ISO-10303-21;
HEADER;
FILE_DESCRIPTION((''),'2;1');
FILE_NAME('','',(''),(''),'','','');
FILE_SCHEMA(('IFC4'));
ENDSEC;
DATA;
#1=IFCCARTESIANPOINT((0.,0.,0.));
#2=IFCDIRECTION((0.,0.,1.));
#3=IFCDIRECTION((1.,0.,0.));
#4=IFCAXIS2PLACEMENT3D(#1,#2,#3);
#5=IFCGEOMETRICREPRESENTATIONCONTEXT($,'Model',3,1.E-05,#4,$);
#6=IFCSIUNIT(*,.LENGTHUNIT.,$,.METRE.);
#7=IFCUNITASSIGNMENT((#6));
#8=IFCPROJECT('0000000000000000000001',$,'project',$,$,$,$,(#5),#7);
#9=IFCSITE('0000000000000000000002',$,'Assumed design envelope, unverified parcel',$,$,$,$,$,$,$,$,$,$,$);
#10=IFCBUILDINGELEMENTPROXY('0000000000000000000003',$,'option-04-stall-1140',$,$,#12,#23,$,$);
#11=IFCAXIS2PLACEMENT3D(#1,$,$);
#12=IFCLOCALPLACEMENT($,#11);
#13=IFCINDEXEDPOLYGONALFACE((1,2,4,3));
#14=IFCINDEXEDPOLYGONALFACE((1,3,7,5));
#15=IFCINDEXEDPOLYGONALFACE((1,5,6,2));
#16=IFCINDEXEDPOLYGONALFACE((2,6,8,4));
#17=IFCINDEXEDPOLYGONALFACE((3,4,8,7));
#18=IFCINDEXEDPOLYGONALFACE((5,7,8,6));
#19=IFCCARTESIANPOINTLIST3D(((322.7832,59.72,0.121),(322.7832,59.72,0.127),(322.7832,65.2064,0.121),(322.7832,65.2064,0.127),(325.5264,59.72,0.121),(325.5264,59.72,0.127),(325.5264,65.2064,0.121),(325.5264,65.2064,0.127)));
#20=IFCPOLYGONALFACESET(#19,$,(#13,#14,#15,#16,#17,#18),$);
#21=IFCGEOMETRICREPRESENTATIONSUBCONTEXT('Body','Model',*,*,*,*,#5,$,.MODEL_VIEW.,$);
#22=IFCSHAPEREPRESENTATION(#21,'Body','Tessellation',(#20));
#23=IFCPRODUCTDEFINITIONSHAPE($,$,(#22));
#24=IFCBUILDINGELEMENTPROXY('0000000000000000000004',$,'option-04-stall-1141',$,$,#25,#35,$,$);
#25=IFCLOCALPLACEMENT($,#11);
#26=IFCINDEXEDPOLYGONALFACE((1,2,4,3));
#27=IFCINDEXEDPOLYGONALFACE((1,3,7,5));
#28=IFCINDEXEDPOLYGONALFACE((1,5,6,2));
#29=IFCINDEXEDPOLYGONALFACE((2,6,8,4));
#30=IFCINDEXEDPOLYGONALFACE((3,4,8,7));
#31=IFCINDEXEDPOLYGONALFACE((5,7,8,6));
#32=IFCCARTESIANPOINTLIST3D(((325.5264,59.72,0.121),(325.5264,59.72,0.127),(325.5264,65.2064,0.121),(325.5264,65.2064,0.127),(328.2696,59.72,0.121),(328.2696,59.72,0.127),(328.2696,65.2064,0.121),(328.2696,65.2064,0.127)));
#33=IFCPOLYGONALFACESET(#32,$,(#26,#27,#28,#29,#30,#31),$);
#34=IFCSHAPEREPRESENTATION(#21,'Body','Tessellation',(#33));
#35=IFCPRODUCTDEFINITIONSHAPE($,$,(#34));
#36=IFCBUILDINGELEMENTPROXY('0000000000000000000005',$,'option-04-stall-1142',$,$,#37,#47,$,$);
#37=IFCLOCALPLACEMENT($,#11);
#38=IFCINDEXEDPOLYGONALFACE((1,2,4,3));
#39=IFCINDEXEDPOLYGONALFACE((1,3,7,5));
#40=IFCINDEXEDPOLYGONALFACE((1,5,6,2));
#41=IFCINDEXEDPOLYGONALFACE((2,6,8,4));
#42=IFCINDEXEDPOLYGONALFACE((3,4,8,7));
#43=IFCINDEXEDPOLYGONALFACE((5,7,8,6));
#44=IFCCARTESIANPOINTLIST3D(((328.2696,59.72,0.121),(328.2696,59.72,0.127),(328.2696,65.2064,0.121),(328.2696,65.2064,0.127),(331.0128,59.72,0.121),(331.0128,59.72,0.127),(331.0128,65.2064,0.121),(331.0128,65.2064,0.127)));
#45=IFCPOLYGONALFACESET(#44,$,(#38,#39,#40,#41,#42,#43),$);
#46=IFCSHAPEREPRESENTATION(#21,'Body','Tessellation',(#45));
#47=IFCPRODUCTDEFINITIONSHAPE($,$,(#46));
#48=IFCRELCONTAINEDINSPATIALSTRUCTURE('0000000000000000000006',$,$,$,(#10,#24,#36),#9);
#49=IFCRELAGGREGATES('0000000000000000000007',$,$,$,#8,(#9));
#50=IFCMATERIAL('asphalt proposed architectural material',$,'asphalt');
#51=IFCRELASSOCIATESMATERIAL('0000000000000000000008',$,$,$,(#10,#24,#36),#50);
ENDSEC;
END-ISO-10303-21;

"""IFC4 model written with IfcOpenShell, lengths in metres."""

from ifc_helpers import new_model, si_unit, frame, origin_with_axes, place, context, subcontext, project, spatial, rectangle, extrude, material, element, save


model = new_model("IFC4")

# Units and contexts
model_context = context("Model", 3, precision=1e-05, world=origin_with_axes())
body_context = subcontext(model_context, "Body", "Model", "MODEL_VIEW")
ifc_project = project(units=[si_unit("LENGTHUNIT", "METRE")], contexts=[model_context])

# Site
site = spatial("IfcSite", under=ifc_project, Name="Assumed design envelope, unverified parcel")

# Building element proxies
ifc_material = material(Name="asphalt proposed architectural material", Category="asphalt")
for number, where, z_axis, x_axis, name in (
    (1, (324.1548, 62.4632, 0.121), (0.0, 0.0, 1.0), (1.0, 0.0, 0.0), "option-04-stall-1140"),
    (2, (326.898, 62.4632, 0.121), (0.0, 0.0, 1.0), (1.0, 0.0, 0.0), "option-04-stall-1141"),
    (3, (329.6412, 62.4632, 0.121), (0.0, 0.0, 1.0), (1.0, 0.0, 0.0), "option-04-stall-1142"),
):
    element("IfcBuildingElementProxy", number, at=place(None, frame(where, z_axis=z_axis, x_axis=x_axis)), inside=site, material=ifc_material, Name=name, context=body_context, shape_type="SweptSolid", body=[
        extrude(rectangle(XDim=2.7432, YDim=5.4864), origin_with_axes(), (0.0, 0.0, 1.0), 0.006),
    ])

save(model, "model.ifc")
